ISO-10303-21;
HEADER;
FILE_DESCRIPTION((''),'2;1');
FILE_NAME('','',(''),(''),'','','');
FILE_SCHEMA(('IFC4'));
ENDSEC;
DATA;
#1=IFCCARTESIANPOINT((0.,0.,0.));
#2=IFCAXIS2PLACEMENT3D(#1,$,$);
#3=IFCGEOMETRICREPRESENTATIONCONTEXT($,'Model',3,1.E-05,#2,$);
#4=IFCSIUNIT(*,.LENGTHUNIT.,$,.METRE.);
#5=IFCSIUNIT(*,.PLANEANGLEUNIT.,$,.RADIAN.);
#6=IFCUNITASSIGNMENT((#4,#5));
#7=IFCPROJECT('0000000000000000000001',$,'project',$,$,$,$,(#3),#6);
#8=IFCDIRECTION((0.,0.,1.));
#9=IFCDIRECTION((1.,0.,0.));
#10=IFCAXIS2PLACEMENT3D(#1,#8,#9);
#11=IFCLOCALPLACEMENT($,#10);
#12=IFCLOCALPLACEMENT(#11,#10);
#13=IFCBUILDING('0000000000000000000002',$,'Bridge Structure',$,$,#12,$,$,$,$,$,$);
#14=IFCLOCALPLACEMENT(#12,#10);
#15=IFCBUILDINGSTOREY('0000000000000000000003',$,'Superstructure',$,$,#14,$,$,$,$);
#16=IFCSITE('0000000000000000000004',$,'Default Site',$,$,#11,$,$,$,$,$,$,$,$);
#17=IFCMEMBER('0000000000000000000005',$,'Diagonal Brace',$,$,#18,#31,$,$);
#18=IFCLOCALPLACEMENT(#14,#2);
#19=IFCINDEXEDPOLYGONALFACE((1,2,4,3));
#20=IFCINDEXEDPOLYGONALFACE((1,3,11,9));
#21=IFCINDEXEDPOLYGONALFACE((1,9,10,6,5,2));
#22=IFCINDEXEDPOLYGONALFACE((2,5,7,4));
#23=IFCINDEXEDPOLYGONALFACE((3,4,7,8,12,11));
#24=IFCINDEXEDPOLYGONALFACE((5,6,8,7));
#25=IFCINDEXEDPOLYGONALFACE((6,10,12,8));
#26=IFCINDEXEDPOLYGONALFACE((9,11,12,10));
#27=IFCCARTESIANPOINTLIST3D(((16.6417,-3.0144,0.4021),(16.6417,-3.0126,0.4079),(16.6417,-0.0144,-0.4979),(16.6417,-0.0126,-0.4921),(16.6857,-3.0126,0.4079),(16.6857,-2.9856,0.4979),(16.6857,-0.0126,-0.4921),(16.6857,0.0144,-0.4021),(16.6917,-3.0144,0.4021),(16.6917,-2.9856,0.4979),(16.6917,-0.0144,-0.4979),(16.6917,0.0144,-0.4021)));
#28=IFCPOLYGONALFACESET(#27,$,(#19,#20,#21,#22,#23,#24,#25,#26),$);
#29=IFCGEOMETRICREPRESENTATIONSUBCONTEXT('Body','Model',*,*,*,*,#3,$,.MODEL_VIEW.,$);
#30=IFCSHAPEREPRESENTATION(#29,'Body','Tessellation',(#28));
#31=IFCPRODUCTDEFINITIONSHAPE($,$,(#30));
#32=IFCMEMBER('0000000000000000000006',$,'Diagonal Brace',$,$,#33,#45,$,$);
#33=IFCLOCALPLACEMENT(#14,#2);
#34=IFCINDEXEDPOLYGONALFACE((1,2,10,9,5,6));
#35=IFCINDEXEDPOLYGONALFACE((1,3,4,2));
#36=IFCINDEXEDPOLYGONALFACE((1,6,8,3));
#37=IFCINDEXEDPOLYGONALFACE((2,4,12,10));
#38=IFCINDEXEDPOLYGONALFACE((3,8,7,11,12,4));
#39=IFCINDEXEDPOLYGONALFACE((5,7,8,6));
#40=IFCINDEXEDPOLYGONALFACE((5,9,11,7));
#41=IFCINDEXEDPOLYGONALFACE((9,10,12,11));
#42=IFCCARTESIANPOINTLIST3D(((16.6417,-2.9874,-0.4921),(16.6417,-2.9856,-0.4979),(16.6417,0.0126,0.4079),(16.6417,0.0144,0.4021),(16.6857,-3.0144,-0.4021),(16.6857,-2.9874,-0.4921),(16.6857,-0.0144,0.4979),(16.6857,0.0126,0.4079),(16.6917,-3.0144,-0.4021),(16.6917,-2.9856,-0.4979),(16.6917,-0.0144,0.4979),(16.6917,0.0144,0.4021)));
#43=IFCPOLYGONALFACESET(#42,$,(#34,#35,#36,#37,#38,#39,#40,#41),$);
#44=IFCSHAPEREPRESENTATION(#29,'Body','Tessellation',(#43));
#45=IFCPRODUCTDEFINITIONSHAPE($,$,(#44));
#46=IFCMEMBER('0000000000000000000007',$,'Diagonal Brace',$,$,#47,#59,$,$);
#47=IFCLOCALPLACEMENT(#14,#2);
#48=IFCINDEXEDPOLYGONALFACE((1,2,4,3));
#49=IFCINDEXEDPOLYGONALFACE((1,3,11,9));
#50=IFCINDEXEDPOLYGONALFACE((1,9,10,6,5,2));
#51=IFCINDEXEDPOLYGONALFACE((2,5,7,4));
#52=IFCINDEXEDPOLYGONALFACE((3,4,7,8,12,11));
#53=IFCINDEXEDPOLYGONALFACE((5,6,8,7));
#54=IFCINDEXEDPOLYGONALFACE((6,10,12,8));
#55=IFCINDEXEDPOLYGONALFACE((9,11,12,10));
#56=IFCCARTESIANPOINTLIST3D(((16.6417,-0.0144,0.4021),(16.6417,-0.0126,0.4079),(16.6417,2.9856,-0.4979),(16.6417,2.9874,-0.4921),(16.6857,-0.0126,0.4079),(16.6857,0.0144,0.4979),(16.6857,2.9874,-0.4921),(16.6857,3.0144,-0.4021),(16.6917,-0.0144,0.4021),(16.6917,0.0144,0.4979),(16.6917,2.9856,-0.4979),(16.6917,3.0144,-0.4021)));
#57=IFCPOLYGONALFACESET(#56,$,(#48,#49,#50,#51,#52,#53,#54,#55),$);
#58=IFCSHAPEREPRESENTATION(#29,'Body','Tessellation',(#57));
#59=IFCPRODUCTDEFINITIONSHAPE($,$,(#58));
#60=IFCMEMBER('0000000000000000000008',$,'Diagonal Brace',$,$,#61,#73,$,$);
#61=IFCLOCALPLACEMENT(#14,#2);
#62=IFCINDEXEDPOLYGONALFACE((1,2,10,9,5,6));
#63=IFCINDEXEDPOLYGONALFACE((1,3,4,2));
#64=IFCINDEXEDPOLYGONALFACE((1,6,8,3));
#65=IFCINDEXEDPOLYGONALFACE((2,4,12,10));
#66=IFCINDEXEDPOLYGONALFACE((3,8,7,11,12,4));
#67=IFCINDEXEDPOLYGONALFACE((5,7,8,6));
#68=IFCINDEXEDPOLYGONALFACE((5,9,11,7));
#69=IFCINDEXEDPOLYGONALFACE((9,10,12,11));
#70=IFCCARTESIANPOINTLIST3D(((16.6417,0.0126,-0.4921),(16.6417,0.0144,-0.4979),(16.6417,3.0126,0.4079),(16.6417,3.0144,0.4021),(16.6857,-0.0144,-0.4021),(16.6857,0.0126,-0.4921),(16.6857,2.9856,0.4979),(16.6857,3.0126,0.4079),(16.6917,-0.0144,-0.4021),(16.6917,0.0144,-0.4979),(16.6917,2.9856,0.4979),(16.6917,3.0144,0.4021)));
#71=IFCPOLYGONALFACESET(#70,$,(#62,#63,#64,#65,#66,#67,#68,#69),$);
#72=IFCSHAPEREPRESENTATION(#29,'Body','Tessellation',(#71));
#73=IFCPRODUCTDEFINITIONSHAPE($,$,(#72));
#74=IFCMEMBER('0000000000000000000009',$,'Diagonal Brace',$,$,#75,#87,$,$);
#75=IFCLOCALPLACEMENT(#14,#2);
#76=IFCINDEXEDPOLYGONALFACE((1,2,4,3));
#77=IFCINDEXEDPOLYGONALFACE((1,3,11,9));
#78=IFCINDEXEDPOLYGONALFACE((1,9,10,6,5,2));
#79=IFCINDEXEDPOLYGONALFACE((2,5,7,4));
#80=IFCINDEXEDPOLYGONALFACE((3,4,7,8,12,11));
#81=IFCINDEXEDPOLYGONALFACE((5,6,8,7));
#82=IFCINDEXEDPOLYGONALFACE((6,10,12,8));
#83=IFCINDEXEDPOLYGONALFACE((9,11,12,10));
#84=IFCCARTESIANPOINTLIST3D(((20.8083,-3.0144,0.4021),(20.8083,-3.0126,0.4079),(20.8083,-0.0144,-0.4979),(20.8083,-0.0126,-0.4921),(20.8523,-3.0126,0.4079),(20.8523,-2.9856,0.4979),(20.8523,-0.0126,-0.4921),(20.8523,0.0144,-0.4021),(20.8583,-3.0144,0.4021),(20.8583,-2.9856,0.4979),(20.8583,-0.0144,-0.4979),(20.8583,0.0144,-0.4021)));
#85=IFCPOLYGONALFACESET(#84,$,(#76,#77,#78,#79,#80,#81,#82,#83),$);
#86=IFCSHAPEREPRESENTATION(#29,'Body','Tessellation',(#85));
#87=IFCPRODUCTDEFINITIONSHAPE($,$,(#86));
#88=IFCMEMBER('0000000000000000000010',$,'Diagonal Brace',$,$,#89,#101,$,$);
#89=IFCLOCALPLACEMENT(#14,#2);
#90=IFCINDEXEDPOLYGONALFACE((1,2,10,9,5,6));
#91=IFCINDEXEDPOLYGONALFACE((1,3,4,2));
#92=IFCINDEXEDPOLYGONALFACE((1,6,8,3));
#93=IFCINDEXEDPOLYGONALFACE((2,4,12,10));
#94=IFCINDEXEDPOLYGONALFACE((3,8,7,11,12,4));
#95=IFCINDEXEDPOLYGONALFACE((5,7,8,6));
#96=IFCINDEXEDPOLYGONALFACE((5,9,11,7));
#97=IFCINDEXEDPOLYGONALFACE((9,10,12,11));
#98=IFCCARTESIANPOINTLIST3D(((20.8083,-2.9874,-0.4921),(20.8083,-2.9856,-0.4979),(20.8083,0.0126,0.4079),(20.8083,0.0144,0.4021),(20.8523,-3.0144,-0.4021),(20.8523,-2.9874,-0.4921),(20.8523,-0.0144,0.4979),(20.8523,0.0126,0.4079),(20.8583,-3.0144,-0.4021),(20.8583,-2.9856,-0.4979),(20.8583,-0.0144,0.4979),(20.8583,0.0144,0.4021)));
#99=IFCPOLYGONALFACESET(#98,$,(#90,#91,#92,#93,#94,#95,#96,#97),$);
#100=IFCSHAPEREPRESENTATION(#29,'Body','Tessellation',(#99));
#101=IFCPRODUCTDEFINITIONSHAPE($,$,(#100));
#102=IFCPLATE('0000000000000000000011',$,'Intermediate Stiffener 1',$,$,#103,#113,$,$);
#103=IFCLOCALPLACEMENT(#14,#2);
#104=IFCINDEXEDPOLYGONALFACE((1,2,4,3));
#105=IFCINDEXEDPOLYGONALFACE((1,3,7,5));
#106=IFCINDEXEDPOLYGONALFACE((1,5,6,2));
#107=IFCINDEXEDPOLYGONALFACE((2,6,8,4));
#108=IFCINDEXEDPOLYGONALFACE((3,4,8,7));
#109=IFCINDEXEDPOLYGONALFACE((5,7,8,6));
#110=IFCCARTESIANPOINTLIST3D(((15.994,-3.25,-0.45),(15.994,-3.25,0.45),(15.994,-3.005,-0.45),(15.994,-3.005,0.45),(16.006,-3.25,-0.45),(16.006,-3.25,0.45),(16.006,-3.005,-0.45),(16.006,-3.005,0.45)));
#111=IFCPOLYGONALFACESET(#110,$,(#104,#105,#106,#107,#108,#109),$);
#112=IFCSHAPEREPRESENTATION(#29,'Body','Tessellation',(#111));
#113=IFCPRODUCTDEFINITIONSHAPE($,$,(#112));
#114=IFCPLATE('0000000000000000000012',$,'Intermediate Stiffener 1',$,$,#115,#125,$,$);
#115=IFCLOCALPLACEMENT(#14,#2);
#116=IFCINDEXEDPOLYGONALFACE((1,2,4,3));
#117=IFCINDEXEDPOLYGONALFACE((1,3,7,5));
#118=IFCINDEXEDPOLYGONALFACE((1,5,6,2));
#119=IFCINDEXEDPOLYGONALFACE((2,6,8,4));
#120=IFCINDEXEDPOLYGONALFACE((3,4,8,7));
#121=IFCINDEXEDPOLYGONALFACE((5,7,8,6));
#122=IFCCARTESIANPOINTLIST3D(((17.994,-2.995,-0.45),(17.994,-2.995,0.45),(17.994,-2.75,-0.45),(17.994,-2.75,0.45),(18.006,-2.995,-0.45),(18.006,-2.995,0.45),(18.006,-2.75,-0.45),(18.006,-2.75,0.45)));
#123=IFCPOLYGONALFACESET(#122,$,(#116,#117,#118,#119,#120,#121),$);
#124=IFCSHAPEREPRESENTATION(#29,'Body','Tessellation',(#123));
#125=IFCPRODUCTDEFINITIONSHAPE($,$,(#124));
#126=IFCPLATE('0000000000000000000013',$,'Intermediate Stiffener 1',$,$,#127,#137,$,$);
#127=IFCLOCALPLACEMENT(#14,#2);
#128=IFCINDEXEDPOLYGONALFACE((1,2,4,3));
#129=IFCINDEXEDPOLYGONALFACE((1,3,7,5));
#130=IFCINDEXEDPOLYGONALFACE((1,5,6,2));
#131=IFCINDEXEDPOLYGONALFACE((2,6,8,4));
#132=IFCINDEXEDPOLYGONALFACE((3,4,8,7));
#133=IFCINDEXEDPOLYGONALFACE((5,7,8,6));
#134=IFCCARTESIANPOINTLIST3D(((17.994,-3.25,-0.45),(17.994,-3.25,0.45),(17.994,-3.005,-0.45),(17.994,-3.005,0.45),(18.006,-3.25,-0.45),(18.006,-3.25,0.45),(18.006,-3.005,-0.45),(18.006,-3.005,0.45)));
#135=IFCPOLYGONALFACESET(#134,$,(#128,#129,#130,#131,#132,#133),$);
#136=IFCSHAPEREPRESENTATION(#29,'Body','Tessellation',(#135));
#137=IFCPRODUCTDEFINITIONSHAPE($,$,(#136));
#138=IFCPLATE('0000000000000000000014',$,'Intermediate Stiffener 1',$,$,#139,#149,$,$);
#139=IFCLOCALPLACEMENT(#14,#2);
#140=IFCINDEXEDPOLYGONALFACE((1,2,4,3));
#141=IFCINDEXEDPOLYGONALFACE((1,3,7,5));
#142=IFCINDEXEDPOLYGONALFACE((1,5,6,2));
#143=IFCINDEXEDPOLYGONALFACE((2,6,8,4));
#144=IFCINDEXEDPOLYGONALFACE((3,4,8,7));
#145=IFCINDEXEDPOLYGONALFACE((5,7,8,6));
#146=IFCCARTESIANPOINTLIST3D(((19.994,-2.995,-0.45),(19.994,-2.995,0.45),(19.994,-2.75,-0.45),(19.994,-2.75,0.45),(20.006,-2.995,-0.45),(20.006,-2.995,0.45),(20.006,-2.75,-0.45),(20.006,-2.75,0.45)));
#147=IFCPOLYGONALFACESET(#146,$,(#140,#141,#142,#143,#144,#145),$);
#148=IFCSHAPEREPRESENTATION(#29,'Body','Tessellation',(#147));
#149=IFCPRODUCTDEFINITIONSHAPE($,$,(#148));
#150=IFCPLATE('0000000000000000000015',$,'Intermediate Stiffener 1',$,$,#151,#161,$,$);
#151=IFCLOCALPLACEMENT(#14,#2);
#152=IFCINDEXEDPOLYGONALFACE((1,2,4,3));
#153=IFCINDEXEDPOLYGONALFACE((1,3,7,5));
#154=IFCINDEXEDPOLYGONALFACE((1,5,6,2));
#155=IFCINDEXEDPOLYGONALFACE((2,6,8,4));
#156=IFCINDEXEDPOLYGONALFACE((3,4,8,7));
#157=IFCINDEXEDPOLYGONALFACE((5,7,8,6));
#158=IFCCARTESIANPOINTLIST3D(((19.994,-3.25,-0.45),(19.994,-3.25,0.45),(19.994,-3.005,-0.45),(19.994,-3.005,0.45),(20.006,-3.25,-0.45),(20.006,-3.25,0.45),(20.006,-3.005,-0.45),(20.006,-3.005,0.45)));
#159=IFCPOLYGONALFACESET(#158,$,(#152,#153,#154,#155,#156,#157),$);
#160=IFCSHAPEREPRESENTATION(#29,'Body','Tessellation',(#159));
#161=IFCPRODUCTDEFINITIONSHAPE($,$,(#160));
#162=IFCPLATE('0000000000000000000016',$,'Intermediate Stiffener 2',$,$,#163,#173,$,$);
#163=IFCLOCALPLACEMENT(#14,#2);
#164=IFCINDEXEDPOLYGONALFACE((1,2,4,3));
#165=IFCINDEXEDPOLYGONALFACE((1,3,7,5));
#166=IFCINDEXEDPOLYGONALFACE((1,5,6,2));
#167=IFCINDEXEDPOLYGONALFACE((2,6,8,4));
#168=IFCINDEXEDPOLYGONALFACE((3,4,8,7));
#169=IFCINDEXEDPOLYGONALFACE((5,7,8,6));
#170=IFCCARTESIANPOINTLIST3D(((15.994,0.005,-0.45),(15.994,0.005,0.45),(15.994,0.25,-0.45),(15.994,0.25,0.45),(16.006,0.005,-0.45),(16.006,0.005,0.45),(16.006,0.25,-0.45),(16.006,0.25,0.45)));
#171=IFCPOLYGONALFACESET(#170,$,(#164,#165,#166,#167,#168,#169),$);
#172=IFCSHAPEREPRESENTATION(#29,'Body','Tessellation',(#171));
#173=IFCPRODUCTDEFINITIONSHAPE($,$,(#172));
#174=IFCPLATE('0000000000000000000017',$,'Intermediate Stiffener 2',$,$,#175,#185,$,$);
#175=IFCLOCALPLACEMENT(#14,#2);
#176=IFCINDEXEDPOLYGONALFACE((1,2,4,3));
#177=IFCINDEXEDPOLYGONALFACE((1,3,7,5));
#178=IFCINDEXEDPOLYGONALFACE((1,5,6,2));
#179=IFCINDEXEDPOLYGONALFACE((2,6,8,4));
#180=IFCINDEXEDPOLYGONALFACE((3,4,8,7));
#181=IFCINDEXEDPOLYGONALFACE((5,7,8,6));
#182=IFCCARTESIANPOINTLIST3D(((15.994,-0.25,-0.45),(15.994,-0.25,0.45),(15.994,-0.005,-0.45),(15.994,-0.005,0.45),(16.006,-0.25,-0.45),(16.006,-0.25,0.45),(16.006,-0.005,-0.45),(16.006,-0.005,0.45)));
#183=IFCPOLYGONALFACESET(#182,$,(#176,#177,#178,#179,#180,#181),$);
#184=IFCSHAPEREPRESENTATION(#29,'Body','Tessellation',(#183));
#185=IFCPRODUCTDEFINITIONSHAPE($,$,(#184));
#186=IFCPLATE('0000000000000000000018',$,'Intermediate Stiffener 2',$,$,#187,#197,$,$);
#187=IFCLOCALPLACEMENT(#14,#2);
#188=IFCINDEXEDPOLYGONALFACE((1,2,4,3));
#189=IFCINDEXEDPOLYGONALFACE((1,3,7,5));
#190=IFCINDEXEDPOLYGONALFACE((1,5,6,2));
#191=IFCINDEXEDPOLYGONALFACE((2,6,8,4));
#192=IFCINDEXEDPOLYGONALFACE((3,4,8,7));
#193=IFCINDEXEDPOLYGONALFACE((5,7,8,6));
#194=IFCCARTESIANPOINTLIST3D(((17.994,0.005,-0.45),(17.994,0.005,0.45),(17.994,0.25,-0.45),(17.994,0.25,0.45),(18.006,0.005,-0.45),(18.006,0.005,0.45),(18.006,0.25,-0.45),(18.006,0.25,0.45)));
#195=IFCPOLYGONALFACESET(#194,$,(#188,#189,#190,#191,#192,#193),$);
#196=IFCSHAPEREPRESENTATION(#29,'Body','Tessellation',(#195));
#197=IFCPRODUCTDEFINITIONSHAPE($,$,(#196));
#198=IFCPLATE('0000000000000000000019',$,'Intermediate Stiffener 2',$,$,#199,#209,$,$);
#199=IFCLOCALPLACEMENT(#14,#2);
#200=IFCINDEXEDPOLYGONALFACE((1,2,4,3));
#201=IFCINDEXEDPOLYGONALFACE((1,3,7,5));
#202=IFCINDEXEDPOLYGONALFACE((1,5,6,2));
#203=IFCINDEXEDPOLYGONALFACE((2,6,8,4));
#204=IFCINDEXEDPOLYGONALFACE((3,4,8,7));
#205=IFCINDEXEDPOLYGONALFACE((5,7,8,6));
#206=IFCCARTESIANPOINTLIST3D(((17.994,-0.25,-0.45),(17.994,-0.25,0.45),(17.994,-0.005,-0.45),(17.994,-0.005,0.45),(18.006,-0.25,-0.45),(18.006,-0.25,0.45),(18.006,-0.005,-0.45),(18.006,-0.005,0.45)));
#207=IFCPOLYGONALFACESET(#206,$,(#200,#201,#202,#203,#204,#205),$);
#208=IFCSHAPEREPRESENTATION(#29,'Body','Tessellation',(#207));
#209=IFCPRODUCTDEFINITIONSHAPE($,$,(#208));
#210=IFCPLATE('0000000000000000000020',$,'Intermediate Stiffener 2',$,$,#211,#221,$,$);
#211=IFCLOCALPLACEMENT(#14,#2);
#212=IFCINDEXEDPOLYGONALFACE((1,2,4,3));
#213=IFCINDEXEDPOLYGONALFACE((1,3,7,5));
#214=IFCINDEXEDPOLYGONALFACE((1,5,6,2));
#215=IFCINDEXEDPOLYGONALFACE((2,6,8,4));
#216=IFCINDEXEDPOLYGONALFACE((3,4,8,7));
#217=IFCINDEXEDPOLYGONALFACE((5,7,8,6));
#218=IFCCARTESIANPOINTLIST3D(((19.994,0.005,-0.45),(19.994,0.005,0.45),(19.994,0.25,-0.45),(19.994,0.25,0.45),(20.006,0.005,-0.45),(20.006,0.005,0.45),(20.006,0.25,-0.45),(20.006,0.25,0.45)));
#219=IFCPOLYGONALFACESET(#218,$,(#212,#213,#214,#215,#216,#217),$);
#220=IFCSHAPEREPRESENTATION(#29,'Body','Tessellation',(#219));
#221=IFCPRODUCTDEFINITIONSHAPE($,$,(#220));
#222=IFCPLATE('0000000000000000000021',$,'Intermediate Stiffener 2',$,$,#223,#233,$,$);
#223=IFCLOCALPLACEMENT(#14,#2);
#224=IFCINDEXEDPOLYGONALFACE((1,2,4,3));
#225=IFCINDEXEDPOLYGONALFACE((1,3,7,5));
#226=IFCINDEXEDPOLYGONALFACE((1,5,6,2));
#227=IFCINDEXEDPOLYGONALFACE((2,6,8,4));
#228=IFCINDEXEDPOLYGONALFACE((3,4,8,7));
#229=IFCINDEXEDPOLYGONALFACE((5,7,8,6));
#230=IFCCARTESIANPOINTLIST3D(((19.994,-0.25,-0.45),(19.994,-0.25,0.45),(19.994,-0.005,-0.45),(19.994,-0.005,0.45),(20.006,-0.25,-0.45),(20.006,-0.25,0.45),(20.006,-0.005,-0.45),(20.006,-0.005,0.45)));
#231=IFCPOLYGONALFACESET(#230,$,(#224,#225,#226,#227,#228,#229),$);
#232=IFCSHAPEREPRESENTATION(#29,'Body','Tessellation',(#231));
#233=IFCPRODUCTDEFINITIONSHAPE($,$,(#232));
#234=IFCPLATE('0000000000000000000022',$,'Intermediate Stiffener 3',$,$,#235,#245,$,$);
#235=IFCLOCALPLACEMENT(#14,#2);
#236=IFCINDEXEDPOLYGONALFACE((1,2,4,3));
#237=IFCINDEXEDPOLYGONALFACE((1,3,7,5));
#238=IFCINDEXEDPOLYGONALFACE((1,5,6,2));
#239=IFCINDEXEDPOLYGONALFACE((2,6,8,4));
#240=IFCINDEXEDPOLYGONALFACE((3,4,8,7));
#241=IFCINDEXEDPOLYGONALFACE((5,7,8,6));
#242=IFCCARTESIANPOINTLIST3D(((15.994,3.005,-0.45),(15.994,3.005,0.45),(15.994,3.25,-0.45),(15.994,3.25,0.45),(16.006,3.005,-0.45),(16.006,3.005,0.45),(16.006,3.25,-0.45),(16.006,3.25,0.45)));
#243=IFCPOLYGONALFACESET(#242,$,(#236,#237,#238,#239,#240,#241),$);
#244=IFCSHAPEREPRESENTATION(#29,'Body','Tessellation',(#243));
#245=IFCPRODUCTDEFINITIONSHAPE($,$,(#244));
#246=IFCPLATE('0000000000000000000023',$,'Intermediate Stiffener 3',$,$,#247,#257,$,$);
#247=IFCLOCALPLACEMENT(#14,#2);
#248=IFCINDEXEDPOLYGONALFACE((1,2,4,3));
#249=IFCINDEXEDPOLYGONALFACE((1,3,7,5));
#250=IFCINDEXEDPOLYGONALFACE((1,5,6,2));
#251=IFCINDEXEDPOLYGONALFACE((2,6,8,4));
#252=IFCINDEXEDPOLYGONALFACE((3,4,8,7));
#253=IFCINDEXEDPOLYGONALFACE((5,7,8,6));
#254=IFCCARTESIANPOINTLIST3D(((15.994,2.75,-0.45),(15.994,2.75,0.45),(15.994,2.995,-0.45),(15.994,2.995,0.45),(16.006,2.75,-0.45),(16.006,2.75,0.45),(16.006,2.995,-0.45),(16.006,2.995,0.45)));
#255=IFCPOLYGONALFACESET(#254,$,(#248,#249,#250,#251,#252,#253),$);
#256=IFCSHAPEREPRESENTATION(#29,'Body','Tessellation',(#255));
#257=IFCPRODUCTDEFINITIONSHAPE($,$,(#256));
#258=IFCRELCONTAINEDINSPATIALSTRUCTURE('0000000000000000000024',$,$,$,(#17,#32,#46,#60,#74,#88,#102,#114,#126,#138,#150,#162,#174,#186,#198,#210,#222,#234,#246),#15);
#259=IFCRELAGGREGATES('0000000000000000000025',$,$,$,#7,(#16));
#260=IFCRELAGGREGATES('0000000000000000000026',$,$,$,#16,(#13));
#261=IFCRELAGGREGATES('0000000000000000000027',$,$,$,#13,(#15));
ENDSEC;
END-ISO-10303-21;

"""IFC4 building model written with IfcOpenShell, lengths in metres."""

from ifc_helpers import new_model, si_unit, frame, origin, origin_with_axes, origin_2d_with_axis, place, context, subcontext, project, spatial, rectangle, l_section, extrude, element, save


model = new_model("IFC4")

# Units and contexts
model_context = context("Model", 3, precision=1e-05, world=origin())
body_context = subcontext(model_context, "Body", "Model", "MODEL_VIEW")
ifc_project = project(units=[si_unit("LENGTHUNIT", "METRE"), si_unit("PLANEANGLEUNIT", "RADIAN")], contexts=[model_context])

# Site, building, storey
site_placement = place(None, origin_with_axes())
site = spatial("IfcSite", under=ifc_project, at=site_placement, Name="Default Site")
building_placement = place(site_placement, origin_with_axes())
building = spatial("IfcBuilding", under=site, at=building_placement, Name="Bridge Structure")
storey_placement = place(building_placement, origin_with_axes())
storey = spatial("IfcBuildingStorey", under=building, at=storey_placement, Name="Superstructure")

# Members
for number, where, z_axis, x_axis, name in (
    (1, (16.6667, -3.0, 0.45), (0.0, 0.957826, -0.287348), (-1.0, 0.0, 0.0), "Diagonal Brace"),
    (2, (16.6667, -3.0, -0.45), (0.0, 0.957826, 0.287348), (-1.0, 0.0, 0.0), "Diagonal Brace"),
    (3, (16.6667, 0.0, 0.45), (0.0, 0.957826, -0.287348), (-1.0, 0.0, 0.0), "Diagonal Brace"),
    (4, (16.6667, 0.0, -0.45), (0.0, 0.957826, 0.287348), (-1.0, 0.0, 0.0), "Diagonal Brace"),
    (5, (20.8333, -3.0, 0.45), (0.0, 0.957826, -0.287348), (-1.0, 0.0, 0.0), "Diagonal Brace"),
    (6, (20.8333, -3.0, -0.45), (0.0, 0.957826, 0.287348), (-1.0, 0.0, 0.0), "Diagonal Brace"),
):
    element("IfcMember", number, at=place(storey_placement, frame(where, z_axis=z_axis, x_axis=x_axis)), inside=storey, Name=name, context=body_context, shape_type="SweptSolid", body=[
        extrude(l_section(Depth=0.1, Width=0.05, Thickness=0.006, at=origin_2d_with_axis()), origin_with_axes(), (0.0, 0.0, 1.0), 3.1321),
    ])

# Plates
for number, where, z_axis, x_axis, name in (
    (7, (16.0, -3.1275, -0.45), (0.0, 0.0, 1.0), (1.0, 0.0, 0.0), "Intermediate Stiffener 1"),
    (8, (18.0, -2.8725, -0.45), (0.0, 0.0, 1.0), (1.0, 0.0, 0.0), "Intermediate Stiffener 1"),
    (9, (18.0, -3.1275, -0.45), (0.0, 0.0, 1.0), (1.0, 0.0, 0.0), "Intermediate Stiffener 1"),
    (10, (20.0, -2.8725, -0.45), (0.0, 0.0, 1.0), (1.0, 0.0, 0.0), "Intermediate Stiffener 1"),
    (11, (20.0, -3.1275, -0.45), (0.0, 0.0, 1.0), (1.0, 0.0, 0.0), "Intermediate Stiffener 1"),
    (12, (16.0, 0.1275, -0.45), (0.0, 0.0, 1.0), (1.0, 0.0, 0.0), "Intermediate Stiffener 2"),
    (13, (16.0, -0.1275, -0.45), (0.0, 0.0, 1.0), (1.0, 0.0, 0.0), "Intermediate Stiffener 2"),
    (14, (18.0, 0.1275, -0.45), (0.0, 0.0, 1.0), (1.0, 0.0, 0.0), "Intermediate Stiffener 2"),
    (15, (18.0, -0.1275, -0.45), (0.0, 0.0, 1.0), (1.0, 0.0, 0.0), "Intermediate Stiffener 2"),
    (16, (20.0, 0.1275, -0.45), (0.0, 0.0, 1.0), (1.0, 0.0, 0.0), "Intermediate Stiffener 2"),
    (17, (20.0, -0.1275, -0.45), (0.0, 0.0, 1.0), (1.0, 0.0, 0.0), "Intermediate Stiffener 2"),
    (18, (16.0, 3.1275, -0.45), (0.0, 0.0, 1.0), (1.0, 0.0, 0.0), "Intermediate Stiffener 3"),
    (19, (16.0, 2.8725, -0.45), (0.0, 0.0, 1.0), (1.0, 0.0, 0.0), "Intermediate Stiffener 3"),
):
    element("IfcPlate", number, at=place(storey_placement, frame(where, z_axis=z_axis, x_axis=x_axis)), inside=storey, Name=name, context=body_context, shape_type="SweptSolid", body=[
        extrude(rectangle(XDim=0.012, YDim=0.245, at=origin_2d_with_axis()), origin_with_axes(), (0.0, 0.0, 1.0), 0.9),
    ])

save(model, "model.ifc")
